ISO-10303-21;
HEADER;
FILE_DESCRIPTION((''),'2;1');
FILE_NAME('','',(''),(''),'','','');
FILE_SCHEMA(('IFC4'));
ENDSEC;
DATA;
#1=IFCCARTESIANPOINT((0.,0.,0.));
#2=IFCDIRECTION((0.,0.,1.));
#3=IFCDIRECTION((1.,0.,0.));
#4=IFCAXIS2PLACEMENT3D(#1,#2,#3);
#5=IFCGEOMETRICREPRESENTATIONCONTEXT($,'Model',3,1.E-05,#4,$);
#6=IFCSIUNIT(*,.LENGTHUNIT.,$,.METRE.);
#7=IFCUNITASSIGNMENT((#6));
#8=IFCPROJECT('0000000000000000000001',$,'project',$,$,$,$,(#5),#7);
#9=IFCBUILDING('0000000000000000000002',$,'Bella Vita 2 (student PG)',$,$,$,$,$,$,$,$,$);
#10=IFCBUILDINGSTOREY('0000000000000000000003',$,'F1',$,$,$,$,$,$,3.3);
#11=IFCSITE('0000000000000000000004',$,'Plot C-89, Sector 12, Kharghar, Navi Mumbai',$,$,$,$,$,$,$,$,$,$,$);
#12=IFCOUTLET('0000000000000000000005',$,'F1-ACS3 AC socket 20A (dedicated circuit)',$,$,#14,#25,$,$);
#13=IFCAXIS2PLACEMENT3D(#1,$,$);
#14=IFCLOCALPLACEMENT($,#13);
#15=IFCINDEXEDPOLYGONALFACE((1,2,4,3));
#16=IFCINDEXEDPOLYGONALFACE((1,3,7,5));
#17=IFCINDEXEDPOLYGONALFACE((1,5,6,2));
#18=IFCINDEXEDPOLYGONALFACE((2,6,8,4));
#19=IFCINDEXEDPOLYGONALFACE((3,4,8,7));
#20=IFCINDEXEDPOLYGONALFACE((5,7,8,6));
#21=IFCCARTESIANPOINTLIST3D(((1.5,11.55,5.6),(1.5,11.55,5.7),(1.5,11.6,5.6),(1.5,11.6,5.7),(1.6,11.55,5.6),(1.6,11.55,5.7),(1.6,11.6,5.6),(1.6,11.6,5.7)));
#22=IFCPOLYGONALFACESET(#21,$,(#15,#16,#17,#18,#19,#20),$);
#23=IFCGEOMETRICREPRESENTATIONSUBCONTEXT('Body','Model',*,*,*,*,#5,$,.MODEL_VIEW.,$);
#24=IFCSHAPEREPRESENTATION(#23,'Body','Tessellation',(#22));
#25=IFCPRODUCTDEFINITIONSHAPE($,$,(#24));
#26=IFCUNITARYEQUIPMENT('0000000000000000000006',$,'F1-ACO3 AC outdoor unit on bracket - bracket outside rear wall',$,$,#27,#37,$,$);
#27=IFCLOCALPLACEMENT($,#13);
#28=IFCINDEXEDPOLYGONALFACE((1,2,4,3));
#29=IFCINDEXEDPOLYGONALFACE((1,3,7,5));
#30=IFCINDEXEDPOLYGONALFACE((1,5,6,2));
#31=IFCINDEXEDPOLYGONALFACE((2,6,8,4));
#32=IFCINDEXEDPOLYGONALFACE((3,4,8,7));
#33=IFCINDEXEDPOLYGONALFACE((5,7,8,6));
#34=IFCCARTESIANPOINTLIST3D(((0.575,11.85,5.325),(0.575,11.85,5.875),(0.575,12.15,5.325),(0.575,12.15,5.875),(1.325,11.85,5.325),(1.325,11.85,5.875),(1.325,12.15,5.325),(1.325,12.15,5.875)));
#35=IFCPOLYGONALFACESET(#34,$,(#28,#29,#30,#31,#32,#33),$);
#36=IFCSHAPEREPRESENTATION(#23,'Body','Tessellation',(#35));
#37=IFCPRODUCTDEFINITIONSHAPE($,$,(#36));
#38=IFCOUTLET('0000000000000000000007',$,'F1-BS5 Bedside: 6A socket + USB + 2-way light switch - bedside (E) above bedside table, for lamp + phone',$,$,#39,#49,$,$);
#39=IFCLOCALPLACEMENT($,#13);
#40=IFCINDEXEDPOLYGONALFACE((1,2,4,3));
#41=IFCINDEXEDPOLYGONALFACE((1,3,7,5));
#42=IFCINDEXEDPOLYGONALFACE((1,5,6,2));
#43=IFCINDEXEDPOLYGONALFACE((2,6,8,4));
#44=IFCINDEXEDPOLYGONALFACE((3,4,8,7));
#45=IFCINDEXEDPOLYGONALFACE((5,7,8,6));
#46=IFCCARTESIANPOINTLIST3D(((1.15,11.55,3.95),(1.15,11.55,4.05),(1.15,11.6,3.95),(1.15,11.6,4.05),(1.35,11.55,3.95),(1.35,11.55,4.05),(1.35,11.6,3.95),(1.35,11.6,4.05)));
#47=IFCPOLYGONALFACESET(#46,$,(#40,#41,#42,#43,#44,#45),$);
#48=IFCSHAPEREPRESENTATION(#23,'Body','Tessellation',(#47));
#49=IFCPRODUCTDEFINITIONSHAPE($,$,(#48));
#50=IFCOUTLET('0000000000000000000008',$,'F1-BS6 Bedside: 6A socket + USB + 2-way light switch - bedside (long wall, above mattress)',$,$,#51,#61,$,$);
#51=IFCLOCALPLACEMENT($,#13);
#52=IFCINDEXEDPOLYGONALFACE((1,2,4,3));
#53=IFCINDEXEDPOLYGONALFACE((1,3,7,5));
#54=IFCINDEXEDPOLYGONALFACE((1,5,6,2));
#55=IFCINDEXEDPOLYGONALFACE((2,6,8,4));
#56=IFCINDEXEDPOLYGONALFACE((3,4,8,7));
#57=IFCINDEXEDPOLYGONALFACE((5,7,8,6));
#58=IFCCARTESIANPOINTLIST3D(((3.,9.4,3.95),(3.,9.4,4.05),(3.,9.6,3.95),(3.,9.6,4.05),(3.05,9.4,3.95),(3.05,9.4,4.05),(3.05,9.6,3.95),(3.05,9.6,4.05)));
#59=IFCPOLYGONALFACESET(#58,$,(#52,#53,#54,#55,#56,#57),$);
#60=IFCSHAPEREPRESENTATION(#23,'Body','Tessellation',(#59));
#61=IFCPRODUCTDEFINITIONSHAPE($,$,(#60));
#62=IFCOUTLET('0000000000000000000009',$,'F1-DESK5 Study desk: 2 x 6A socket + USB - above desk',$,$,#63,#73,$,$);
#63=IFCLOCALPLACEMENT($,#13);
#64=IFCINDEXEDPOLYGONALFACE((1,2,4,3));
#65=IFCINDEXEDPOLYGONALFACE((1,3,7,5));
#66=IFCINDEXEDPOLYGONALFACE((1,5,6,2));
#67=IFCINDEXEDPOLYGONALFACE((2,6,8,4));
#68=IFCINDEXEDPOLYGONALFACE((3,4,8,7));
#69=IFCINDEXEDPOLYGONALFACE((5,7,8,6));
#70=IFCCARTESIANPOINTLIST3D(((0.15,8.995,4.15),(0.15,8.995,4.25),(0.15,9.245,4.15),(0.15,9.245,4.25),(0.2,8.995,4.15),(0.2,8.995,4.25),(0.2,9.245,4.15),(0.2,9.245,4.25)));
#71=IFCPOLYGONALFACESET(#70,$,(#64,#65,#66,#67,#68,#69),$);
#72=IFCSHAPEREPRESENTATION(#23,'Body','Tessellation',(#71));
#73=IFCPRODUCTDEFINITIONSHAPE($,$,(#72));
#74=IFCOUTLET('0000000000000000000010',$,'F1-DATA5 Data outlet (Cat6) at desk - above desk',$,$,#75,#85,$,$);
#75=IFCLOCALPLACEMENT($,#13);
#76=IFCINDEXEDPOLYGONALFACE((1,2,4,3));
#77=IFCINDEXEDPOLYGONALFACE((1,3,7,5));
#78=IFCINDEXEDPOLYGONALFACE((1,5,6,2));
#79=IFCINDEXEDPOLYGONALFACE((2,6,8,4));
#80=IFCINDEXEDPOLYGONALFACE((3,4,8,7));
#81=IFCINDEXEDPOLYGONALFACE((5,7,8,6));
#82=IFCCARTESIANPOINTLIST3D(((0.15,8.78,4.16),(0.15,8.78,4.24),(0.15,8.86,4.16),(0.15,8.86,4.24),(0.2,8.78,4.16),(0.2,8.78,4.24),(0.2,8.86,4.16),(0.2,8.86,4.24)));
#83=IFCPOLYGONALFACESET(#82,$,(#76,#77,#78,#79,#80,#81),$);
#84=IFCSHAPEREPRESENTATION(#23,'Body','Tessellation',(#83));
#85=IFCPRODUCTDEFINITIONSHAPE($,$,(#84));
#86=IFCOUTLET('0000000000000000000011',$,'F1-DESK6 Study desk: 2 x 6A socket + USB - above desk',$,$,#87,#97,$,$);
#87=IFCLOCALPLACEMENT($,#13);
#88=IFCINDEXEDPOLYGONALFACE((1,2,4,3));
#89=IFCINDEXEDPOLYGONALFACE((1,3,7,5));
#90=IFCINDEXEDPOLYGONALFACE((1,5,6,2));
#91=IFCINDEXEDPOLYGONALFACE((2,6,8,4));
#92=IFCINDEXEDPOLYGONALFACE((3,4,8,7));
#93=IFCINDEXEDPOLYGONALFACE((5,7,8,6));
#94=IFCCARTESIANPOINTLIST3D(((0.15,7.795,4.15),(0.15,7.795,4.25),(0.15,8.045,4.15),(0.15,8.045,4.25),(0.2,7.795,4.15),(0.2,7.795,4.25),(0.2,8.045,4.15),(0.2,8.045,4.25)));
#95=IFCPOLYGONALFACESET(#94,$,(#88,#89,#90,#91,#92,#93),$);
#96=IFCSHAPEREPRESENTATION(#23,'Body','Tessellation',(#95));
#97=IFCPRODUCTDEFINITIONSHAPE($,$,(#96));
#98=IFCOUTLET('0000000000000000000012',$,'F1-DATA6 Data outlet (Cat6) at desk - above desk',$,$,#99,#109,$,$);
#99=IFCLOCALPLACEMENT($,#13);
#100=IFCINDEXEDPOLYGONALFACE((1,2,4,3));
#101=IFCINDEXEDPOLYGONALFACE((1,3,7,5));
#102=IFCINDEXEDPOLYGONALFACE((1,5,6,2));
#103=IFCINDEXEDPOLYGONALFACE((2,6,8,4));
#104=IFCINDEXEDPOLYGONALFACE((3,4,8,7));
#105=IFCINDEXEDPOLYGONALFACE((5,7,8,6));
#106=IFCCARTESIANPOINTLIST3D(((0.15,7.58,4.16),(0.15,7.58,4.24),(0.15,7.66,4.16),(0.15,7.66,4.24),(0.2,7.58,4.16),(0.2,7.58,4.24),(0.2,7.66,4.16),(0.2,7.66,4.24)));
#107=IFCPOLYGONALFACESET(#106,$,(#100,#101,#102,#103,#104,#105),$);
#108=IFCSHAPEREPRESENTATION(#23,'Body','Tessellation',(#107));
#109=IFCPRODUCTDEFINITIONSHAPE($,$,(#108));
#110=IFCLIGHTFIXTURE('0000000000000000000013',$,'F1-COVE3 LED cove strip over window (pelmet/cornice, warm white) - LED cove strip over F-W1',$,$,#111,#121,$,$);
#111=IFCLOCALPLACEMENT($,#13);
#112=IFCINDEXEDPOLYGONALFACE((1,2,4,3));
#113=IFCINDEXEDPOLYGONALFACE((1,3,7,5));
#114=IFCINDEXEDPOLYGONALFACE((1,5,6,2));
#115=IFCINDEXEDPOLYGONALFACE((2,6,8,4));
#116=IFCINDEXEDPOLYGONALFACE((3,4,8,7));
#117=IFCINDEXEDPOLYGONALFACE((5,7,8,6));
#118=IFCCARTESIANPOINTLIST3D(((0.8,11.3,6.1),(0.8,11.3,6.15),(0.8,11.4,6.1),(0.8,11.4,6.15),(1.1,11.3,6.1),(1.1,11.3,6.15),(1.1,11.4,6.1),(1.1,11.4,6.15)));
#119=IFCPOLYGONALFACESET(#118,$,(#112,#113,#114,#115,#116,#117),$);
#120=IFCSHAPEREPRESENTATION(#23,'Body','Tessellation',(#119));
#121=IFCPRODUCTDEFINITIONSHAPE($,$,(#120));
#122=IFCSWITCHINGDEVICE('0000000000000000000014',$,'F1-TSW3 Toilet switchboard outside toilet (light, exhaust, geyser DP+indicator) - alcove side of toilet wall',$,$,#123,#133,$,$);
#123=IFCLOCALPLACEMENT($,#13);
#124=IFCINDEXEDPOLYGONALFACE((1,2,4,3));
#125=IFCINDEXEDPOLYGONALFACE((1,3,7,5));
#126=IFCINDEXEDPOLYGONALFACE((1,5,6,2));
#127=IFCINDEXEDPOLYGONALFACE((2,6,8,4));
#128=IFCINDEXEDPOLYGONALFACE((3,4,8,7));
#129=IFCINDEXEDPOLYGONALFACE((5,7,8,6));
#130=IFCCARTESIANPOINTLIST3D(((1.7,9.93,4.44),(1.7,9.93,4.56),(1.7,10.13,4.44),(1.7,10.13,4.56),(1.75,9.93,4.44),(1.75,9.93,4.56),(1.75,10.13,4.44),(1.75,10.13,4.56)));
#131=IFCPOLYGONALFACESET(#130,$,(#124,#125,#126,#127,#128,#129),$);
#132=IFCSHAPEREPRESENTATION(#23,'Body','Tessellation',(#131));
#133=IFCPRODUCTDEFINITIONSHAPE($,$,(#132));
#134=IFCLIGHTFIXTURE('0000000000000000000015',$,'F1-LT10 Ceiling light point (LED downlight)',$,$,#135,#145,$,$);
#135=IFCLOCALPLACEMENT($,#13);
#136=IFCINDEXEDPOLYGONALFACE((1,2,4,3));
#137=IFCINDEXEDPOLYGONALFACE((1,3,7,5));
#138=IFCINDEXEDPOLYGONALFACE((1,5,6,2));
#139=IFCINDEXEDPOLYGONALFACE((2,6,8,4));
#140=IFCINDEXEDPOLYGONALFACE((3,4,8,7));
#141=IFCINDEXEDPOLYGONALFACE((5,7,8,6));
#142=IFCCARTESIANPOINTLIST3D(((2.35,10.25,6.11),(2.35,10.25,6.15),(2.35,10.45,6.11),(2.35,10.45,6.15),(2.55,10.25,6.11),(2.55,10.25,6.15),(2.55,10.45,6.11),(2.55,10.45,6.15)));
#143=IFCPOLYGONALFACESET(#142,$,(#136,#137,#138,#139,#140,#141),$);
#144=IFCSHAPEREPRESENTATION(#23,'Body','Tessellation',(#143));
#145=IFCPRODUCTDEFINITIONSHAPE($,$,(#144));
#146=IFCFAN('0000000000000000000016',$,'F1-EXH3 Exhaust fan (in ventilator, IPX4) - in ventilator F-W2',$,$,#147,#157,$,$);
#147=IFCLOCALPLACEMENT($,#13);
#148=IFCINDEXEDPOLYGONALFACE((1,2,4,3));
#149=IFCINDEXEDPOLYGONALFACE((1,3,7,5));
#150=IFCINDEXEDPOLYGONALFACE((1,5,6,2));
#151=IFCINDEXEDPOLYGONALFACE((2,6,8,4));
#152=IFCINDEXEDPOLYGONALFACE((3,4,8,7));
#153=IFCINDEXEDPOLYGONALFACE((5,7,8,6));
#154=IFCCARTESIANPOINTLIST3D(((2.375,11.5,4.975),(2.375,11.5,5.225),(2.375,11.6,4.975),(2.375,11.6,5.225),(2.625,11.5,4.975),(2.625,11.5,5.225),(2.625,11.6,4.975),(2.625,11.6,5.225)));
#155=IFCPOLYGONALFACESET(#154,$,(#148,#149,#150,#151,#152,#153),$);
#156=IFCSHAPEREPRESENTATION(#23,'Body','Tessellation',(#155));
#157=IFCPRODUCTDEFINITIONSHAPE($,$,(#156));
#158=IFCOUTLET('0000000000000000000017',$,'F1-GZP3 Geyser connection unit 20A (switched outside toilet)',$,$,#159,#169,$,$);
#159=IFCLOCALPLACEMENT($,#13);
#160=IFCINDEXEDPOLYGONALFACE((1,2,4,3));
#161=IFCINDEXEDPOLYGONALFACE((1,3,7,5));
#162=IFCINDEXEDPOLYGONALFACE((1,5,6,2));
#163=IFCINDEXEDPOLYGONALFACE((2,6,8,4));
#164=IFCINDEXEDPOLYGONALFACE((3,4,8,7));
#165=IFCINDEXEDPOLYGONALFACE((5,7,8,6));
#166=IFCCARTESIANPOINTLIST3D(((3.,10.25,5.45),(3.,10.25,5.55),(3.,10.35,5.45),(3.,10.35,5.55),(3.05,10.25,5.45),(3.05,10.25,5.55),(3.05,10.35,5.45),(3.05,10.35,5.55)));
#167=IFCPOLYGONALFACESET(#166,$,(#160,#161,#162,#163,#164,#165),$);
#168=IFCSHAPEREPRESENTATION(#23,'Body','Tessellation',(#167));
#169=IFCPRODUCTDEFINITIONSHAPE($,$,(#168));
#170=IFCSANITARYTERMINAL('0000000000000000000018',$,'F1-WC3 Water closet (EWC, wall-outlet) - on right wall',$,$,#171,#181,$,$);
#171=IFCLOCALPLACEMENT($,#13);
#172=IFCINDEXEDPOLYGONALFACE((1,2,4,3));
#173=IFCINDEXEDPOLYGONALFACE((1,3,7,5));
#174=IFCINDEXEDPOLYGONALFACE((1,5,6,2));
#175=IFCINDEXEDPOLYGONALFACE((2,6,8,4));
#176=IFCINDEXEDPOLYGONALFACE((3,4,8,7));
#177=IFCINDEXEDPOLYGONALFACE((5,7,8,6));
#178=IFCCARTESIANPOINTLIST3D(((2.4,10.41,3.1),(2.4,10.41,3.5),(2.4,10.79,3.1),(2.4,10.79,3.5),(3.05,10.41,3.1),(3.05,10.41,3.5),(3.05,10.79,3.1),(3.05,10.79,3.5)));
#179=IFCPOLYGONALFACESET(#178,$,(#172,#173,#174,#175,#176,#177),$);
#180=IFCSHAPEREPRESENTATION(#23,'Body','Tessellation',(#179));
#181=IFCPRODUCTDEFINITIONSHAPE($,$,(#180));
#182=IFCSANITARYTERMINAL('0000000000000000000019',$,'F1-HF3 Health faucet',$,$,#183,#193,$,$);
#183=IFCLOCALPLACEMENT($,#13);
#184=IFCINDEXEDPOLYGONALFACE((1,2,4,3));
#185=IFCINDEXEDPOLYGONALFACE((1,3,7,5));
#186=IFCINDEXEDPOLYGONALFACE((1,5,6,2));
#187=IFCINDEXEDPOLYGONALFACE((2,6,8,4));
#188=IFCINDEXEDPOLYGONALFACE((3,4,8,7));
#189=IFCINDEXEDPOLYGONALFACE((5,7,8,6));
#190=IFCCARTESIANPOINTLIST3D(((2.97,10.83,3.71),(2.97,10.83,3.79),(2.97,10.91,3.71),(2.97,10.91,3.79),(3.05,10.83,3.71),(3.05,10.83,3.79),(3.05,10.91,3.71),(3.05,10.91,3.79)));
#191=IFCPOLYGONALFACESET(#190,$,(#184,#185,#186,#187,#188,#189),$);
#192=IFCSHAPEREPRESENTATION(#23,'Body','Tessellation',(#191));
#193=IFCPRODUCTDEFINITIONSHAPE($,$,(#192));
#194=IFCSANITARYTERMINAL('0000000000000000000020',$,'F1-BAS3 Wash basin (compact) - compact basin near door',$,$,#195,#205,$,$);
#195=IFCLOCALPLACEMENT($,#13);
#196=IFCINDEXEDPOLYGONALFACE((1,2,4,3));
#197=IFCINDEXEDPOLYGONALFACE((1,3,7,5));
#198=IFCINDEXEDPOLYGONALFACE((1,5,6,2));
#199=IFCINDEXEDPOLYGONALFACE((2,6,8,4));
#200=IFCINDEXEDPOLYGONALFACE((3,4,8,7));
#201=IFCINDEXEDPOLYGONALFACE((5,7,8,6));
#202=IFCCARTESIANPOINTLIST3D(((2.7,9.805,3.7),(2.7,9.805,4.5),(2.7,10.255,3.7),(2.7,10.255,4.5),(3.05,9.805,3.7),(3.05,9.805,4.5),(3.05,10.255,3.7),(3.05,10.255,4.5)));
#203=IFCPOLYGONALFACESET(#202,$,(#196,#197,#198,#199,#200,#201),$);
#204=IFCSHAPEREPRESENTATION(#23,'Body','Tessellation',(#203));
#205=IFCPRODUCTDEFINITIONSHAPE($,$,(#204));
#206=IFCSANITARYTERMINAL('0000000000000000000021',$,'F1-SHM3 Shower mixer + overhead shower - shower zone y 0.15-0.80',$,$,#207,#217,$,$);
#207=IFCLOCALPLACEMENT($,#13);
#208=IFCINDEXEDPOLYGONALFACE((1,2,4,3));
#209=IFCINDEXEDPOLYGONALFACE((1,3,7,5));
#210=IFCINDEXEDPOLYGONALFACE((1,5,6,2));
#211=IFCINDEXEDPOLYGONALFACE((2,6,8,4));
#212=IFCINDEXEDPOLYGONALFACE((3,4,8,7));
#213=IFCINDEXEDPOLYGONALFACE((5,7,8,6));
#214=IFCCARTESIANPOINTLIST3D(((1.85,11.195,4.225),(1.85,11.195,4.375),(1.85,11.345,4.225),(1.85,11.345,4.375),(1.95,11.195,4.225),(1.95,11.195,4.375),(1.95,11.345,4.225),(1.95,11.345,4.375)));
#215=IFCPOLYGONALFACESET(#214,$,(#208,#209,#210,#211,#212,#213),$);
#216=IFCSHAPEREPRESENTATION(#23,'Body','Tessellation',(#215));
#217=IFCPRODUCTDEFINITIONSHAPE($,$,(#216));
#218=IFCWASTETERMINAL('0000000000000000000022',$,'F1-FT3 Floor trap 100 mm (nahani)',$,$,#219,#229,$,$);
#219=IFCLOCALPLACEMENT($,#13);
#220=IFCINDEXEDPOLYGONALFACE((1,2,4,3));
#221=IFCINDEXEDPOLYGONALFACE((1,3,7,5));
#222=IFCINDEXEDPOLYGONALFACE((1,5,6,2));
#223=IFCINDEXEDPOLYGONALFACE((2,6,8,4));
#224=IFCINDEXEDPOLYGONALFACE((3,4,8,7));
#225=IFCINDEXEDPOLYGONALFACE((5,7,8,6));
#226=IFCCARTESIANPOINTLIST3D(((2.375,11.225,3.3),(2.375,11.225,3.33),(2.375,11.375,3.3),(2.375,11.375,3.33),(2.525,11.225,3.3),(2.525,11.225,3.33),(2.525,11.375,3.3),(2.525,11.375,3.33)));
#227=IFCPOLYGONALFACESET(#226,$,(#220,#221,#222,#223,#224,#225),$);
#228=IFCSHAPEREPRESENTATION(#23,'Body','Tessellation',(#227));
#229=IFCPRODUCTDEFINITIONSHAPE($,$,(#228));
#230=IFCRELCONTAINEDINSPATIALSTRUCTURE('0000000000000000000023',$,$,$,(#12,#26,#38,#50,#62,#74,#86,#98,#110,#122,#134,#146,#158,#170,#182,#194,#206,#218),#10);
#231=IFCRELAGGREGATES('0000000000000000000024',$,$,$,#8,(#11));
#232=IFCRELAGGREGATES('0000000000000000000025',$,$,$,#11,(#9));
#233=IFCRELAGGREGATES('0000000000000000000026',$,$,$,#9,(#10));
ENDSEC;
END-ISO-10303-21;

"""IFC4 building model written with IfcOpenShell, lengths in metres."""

from ifc_helpers import new_model, si_unit, frame, origin, origin_with_axes, origin_2d, place, context, subcontext, project, spatial, rectangle, extrude, element, save


model = new_model("IFC4")

# Units and contexts
model_context = context("Model", 3, precision=1e-05, world=origin_with_axes())
body_context = subcontext(model_context, "Body", "Model", "MODEL_VIEW")
ifc_project = project(units=[si_unit("LENGTHUNIT", "METRE")], contexts=[model_context])

# Site, building, storey
site = spatial("IfcSite", under=ifc_project, Name="Plot C-89, Sector 12, Kharghar, Navi Mumbai")
building = spatial("IfcBuilding", under=site, Name="Bella Vita 2 (student PG)")
storey = spatial("IfcBuildingStorey", under=building, Name="F1", Elevation=3.3)

# Outlet
outlet_1_placement = place(None, origin())
element("IfcOutlet", 1, at=outlet_1_placement, inside=storey, Name="F1-ACS3 AC socket 20A (dedicated circuit)", context=body_context, shape_type="SweptSolid", body=[
    extrude(rectangle(XDim=0.1, YDim=0.05, at=origin_2d()), frame((1.55, 11.575, 5.6)), (0.0, 0.0, 1.0), 0.1),
])

# Unitary equipment
unitary_equipment_1_placement = place(None, origin())
element("IfcUnitaryEquipment", 2, at=unitary_equipment_1_placement, inside=storey, Name="F1-ACO3 AC outdoor unit on bracket - bracket outside rear wall", context=body_context, shape_type="SweptSolid", body=[
    extrude(rectangle(XDim=0.75, YDim=0.3, at=origin_2d()), frame((0.95, 12.0, 5.325)), (0.0, 0.0, 1.0), 0.55),
])

# Outlets
outlet_2_placement = place(None, origin())
element("IfcOutlet", 3, at=outlet_2_placement, inside=storey, Name="F1-BS5 Bedside: 6A socket + USB + 2-way light switch - bedside (E) above bedside table, for lamp + phone", context=body_context, shape_type="SweptSolid", body=[
    extrude(rectangle(XDim=0.2, YDim=0.05, at=origin_2d()), frame((1.25, 11.575, 3.95)), (0.0, 0.0, 1.0), 0.1),
])
outlet_3_placement = place(None, origin())
element("IfcOutlet", 4, at=outlet_3_placement, inside=storey, Name="F1-BS6 Bedside: 6A socket + USB + 2-way light switch - bedside (long wall, above mattress)", context=body_context, shape_type="SweptSolid", body=[
    extrude(rectangle(XDim=0.05, YDim=0.2, at=origin_2d()), frame((3.025, 9.5, 3.95)), (0.0, 0.0, 1.0), 0.1),
])
outlet_4_placement = place(None, origin())
element("IfcOutlet", 5, at=outlet_4_placement, inside=storey, Name="F1-DESK5 Study desk: 2 x 6A socket + USB - above desk", context=body_context, shape_type="SweptSolid", body=[
    extrude(rectangle(XDim=0.05, YDim=0.25, at=origin_2d()), frame((0.175, 9.12, 4.15)), (0.0, 0.0, 1.0), 0.1),
])
outlet_5_placement = place(None, origin())
element("IfcOutlet", 6, at=outlet_5_placement, inside=storey, Name="F1-DATA5 Data outlet (Cat6) at desk - above desk", context=body_context, shape_type="SweptSolid", body=[
    extrude(rectangle(XDim=0.05, YDim=0.08, at=origin_2d()), frame((0.175, 8.82, 4.16)), (0.0, 0.0, 1.0), 0.08),
])
outlet_6_placement = place(None, origin())
element("IfcOutlet", 7, at=outlet_6_placement, inside=storey, Name="F1-DESK6 Study desk: 2 x 6A socket + USB - above desk", context=body_context, shape_type="SweptSolid", body=[
    extrude(rectangle(XDim=0.05, YDim=0.25, at=origin_2d()), frame((0.175, 7.92, 4.15)), (0.0, 0.0, 1.0), 0.1),
])
outlet_7_placement = place(None, origin())
element("IfcOutlet", 8, at=outlet_7_placement, inside=storey, Name="F1-DATA6 Data outlet (Cat6) at desk - above desk", context=body_context, shape_type="SweptSolid", body=[
    extrude(rectangle(XDim=0.05, YDim=0.08, at=origin_2d()), frame((0.175, 7.62, 4.16)), (0.0, 0.0, 1.0), 0.08),
])

# Light fixture
light_fixture_1_placement = place(None, origin())
element("IfcLightFixture", 9, at=light_fixture_1_placement, inside=storey, Name="F1-COVE3 LED cove strip over window (pelmet/cornice, warm white) - LED cove strip over F-W1", context=body_context, shape_type="SweptSolid", body=[
    extrude(rectangle(XDim=0.3, YDim=0.1, at=origin_2d()), frame((0.95, 11.35, 6.1)), (0.0, 0.0, 1.0), 0.05),
])

# Switching device
switching_device_1_placement = place(None, origin())
element("IfcSwitchingDevice", 10, at=switching_device_1_placement, inside=storey, Name="F1-TSW3 Toilet switchboard outside toilet (light, exhaust, geyser DP+indicator) - alcove side of toilet wall", context=body_context, shape_type="SweptSolid", body=[
    extrude(rectangle(XDim=0.05, YDim=0.2, at=origin_2d()), frame((1.725, 10.03, 4.44)), (0.0, 0.0, 1.0), 0.12),
])

# Light fixture
light_fixture_2_placement = place(None, origin())
element("IfcLightFixture", 11, at=light_fixture_2_placement, inside=storey, Name="F1-LT10 Ceiling light point (LED downlight)", context=body_context, shape_type="SweptSolid", body=[
    extrude(rectangle(XDim=0.2, YDim=0.2, at=origin_2d()), frame((2.45, 10.35, 6.11)), (0.0, 0.0, 1.0), 0.04),
])

# Fan
fan_1_placement = place(None, origin())
element("IfcFan", 12, at=fan_1_placement, inside=storey, Name="F1-EXH3 Exhaust fan (in ventilator, IPX4) - in ventilator F-W2", context=body_context, shape_type="SweptSolid", body=[
    extrude(rectangle(XDim=0.25, YDim=0.1, at=origin_2d()), frame((2.5, 11.55, 4.975)), (0.0, 0.0, 1.0), 0.25),
])

# Outlet
outlet_8_placement = place(None, origin())
element("IfcOutlet", 13, at=outlet_8_placement, inside=storey, Name="F1-GZP3 Geyser connection unit 20A (switched outside toilet)", context=body_context, shape_type="SweptSolid", body=[
    extrude(rectangle(XDim=0.05, YDim=0.1, at=origin_2d()), frame((3.025, 10.3, 5.45)), (0.0, 0.0, 1.0), 0.1),
])

# Sanitary terminals
sanitary_terminal_1_placement = place(None, origin())
element("IfcSanitaryTerminal", 14, at=sanitary_terminal_1_placement, inside=storey, Name="F1-WC3 Water closet (EWC, wall-outlet) - on right wall", context=body_context, shape_type="SweptSolid", body=[
    extrude(rectangle(XDim=0.65, YDim=0.38, at=origin_2d()), frame((2.725, 10.6, 3.1)), (0.0, 0.0, 1.0), 0.4),
])
sanitary_terminal_2_placement = place(None, origin())
element("IfcSanitaryTerminal", 15, at=sanitary_terminal_2_placement, inside=storey, Name="F1-HF3 Health faucet", context=body_context, shape_type="SweptSolid", body=[
    extrude(rectangle(XDim=0.08, YDim=0.08, at=origin_2d()), frame((3.01, 10.87, 3.71)), (0.0, 0.0, 1.0), 0.08),
])
sanitary_terminal_3_placement = place(None, origin())
element("IfcSanitaryTerminal", 16, at=sanitary_terminal_3_placement, inside=storey, Name="F1-BAS3 Wash basin (compact) - compact basin near door", context=body_context, shape_type="SweptSolid", body=[
    extrude(rectangle(XDim=0.35, YDim=0.45, at=origin_2d()), frame((2.875, 10.03, 3.7)), (0.0, 0.0, 1.0), 0.8),
])
sanitary_terminal_4_placement = place(None, origin())
element("IfcSanitaryTerminal", 17, at=sanitary_terminal_4_placement, inside=storey, Name="F1-SHM3 Shower mixer + overhead shower - shower zone y 0.15-0.80", context=body_context, shape_type="SweptSolid", body=[
    extrude(rectangle(XDim=0.1, YDim=0.15, at=origin_2d()), frame((1.9, 11.27, 4.225)), (0.0, 0.0, 1.0), 0.15),
])

# Waste terminal
waste_terminal_1_placement = place(None, origin())
element("IfcWasteTerminal", 18, at=waste_terminal_1_placement, inside=storey, Name="F1-FT3 Floor trap 100 mm (nahani)", context=body_context, shape_type="SweptSolid", body=[
    extrude(rectangle(XDim=0.15, YDim=0.15, at=origin_2d()), frame((2.45, 11.3, 3.3)), (0.0, 0.0, 1.0), 0.03),
])

save(model, "model.ifc")
